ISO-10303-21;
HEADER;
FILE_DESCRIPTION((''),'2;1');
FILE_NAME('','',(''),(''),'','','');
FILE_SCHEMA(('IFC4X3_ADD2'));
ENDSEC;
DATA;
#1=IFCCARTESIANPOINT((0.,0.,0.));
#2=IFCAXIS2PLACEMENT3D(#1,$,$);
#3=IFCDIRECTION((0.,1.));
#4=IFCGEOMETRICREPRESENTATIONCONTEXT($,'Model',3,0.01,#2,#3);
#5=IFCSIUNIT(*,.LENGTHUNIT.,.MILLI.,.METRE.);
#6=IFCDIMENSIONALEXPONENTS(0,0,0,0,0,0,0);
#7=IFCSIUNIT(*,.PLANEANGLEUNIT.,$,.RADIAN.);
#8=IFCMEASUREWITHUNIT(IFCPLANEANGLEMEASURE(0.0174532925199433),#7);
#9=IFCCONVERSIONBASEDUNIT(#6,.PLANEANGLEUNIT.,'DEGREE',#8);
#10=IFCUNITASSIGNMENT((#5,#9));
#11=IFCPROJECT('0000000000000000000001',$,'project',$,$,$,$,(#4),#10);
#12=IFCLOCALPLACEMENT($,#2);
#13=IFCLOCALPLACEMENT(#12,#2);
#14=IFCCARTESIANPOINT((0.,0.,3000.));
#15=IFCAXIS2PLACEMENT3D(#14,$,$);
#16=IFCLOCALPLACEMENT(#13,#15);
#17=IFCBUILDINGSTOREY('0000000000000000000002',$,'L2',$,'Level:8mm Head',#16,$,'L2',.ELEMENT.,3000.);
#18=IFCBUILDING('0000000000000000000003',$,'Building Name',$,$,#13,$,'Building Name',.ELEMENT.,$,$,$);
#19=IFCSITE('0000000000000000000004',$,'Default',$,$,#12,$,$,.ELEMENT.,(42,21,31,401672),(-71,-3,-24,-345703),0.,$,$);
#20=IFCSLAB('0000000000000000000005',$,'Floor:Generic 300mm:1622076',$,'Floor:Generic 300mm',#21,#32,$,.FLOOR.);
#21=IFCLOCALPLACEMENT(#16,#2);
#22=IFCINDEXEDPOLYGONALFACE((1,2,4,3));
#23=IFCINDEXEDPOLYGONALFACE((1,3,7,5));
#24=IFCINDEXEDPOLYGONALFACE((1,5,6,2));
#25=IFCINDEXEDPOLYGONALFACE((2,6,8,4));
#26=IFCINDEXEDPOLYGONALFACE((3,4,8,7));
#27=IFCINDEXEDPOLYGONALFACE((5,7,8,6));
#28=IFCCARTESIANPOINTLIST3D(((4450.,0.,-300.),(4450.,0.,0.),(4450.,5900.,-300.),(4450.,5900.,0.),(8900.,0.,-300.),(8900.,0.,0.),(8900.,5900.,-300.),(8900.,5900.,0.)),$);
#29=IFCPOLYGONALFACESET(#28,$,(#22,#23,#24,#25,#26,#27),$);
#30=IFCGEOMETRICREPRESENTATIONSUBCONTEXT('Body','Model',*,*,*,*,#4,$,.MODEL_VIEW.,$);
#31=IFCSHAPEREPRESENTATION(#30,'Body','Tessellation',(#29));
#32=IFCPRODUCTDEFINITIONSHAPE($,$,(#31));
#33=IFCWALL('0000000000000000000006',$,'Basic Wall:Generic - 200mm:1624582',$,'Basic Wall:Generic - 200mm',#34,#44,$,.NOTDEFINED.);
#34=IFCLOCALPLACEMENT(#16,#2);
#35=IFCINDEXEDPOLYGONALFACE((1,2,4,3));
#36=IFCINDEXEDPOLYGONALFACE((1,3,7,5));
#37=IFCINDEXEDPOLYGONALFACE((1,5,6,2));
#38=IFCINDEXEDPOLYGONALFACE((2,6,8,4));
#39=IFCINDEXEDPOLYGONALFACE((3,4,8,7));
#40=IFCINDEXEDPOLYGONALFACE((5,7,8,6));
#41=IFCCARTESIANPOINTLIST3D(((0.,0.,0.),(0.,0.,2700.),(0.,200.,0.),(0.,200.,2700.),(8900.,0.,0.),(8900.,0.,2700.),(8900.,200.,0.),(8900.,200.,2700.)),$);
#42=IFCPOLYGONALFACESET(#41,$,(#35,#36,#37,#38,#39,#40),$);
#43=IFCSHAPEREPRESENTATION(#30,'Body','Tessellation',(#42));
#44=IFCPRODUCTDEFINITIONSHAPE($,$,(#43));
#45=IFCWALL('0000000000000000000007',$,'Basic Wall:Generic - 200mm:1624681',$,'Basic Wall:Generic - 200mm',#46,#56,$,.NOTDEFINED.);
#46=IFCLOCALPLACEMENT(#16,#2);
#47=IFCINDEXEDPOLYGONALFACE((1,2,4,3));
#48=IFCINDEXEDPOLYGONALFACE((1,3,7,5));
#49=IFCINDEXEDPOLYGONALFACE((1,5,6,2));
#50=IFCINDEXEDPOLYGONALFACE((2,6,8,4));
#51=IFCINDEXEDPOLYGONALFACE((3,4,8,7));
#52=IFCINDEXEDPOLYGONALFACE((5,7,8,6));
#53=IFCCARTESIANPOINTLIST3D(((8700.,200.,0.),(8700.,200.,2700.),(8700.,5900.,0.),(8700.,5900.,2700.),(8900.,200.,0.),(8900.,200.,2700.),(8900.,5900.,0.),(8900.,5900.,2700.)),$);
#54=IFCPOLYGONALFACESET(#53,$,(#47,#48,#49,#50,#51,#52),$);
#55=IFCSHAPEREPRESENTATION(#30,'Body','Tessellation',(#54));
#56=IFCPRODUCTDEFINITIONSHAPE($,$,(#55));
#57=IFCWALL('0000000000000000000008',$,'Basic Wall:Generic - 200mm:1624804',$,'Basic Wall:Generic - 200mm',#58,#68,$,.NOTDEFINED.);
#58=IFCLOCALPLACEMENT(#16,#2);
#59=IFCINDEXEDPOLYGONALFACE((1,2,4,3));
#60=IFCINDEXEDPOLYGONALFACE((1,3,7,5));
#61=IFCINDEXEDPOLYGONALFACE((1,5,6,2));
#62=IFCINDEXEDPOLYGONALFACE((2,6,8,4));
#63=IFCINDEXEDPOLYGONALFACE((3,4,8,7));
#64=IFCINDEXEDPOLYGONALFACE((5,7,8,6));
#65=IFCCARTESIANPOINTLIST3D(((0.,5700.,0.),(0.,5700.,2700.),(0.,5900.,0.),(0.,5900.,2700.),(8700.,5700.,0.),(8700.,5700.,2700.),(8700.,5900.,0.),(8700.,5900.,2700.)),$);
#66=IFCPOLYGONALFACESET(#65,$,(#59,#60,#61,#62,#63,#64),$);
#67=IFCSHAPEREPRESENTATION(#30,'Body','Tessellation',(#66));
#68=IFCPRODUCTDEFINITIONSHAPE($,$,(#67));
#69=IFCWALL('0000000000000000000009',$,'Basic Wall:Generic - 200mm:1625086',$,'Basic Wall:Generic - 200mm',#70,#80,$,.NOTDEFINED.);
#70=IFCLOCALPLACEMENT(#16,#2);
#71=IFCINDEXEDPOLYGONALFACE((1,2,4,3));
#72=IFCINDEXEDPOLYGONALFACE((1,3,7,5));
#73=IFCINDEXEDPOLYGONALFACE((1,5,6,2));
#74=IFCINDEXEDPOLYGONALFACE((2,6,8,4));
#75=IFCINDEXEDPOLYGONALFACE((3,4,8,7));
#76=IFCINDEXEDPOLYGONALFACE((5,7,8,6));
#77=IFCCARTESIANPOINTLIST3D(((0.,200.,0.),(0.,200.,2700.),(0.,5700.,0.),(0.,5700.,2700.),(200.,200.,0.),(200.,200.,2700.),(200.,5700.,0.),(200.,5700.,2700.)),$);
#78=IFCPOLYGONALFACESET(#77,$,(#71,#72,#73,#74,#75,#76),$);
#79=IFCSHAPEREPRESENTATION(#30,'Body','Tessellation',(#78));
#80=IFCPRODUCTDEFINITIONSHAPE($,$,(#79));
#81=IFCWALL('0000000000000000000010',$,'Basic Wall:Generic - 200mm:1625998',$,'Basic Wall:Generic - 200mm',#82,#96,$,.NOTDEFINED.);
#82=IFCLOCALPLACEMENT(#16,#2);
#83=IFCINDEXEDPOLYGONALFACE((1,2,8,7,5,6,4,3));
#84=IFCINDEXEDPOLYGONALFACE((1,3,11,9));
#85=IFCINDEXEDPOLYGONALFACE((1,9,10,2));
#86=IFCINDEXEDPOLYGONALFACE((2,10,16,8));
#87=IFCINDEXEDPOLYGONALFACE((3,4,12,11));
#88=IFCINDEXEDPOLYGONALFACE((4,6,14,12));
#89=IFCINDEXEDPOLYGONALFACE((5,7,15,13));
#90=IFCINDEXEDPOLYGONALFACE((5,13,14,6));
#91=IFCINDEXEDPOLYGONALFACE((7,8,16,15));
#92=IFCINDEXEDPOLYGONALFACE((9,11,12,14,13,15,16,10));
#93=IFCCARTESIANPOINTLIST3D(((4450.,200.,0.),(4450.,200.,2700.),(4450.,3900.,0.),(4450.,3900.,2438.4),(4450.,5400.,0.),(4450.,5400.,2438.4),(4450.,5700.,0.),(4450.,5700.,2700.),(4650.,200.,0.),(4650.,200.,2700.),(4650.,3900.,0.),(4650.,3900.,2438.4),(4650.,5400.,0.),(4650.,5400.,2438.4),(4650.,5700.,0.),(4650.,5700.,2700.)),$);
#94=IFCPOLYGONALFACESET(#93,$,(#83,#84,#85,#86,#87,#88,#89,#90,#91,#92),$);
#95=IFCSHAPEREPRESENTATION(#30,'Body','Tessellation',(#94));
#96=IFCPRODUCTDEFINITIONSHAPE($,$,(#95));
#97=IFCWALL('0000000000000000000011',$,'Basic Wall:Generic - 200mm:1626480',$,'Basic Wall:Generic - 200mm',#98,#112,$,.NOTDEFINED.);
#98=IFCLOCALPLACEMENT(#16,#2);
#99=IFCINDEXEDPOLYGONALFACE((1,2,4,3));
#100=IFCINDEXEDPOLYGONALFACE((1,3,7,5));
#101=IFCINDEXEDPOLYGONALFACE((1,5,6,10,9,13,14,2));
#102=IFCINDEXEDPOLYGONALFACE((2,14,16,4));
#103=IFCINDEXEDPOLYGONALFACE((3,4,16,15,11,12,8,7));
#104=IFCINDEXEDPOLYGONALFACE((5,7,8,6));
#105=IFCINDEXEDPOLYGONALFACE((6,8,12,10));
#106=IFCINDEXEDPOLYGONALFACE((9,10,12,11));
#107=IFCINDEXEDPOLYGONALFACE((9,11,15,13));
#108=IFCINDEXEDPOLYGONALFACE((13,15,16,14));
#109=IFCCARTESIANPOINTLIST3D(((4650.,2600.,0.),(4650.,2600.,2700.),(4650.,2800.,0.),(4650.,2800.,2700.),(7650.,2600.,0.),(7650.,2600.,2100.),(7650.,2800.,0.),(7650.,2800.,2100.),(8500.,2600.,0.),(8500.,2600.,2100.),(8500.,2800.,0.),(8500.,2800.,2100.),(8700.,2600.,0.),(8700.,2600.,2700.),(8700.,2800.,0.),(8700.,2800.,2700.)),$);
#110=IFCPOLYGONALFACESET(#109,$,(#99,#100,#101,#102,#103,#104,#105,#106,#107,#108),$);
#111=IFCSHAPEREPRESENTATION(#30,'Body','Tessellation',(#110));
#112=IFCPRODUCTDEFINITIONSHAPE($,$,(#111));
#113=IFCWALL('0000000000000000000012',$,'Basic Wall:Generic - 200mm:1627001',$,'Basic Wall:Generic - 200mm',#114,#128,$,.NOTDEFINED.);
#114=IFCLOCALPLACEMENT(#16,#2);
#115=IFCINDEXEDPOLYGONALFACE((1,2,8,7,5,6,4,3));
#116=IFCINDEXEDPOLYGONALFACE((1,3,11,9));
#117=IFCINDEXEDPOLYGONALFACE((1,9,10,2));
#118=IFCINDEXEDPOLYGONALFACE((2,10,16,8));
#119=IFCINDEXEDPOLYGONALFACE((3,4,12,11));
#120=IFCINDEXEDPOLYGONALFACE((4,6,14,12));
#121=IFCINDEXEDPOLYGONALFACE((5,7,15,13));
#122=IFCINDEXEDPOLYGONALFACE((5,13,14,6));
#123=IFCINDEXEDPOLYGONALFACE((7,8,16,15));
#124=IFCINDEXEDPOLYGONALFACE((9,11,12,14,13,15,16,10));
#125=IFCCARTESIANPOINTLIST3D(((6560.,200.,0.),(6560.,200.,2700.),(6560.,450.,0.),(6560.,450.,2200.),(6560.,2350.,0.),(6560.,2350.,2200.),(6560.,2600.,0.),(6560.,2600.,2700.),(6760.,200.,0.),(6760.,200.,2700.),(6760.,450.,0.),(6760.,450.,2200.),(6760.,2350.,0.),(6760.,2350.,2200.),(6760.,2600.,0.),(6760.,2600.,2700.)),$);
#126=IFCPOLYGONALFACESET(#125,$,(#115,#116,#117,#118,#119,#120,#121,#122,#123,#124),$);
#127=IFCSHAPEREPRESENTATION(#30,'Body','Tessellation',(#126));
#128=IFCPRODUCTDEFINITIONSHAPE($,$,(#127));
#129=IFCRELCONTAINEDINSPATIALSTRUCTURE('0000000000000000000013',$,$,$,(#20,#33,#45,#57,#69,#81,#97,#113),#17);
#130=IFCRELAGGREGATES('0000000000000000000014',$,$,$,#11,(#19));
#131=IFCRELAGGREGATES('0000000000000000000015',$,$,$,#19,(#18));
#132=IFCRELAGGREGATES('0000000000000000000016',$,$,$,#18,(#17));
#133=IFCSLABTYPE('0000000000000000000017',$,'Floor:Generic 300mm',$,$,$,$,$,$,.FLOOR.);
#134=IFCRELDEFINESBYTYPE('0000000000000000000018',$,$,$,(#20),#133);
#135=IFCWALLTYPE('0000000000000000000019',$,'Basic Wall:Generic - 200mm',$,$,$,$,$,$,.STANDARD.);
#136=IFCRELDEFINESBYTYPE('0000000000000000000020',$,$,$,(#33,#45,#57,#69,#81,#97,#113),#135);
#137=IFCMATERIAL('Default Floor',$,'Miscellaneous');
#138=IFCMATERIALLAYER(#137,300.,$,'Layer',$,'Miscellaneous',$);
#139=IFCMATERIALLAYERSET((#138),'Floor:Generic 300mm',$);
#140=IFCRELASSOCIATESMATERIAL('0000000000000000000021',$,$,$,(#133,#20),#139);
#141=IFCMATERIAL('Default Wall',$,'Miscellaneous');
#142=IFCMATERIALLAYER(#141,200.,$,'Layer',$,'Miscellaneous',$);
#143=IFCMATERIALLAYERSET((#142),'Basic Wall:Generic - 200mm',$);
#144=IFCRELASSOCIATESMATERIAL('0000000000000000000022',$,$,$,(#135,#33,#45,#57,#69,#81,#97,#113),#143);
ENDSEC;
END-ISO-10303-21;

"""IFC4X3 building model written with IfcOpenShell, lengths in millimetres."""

from ifc_helpers import new_model, entity, si_unit, converted_unit, direction, frame, frame_2d, origin, origin_2d_with_axis, place, context, subcontext, project, spatial, rectangle, extrude, material, layer, layer_set, layer_usage, type_object, element, save


model = new_model("IFC4X3")

# Units and contexts
model_context = context("Model", 3, precision=0.01, world=origin(), true_north=direction((0.0, 1.0)))
body_context = subcontext(model_context, "Body", "Model", "MODEL_VIEW")
ifc_project = project(units=[si_unit("LENGTHUNIT", "METRE", prefix="MILLI"), converted_unit("PLANEANGLEUNIT", "DEGREE", entity("IfcPlaneAngleMeasure", 0.0174532925199433), si_unit("PLANEANGLEUNIT", "RADIAN"), dimensions=[0, 0, 0, 0, 0, 0, 0])], contexts=[model_context])

# Site, building, storey
site_placement = place(None, origin())
site = spatial("IfcSite", under=ifc_project, at=site_placement, Name="Default", CompositionType="ELEMENT", RefLatitude=(42, 21, 31, 401672), RefLongitude=(-71, -3, -24, -345703), RefElevation=0.0)
building_placement = place(site_placement, origin())
building = spatial("IfcBuilding", under=site, at=building_placement, Name="Building Name", LongName="Building Name", CompositionType="ELEMENT")
storey_placement = place(building_placement, frame((0.0, 0.0, 3000.0)))
storey = spatial("IfcBuildingStorey", under=building, at=storey_placement, Name="L2", ObjectType="Level:8mm Head", LongName="L2", CompositionType="ELEMENT", Elevation=3000.0)

# Slab
ifc_material_1 = material(Name="Default Floor", Category="Miscellaneous")
ifc_layer_1 = layer(ifc_material_1, 300.0, Name="Layer", Category="Miscellaneous")
ifc_layer_set_1 = layer_set([ifc_layer_1], Name="Floor:Generic 300mm")
ifc_layer_usage = layer_usage(ifc_layer_set_1, "AXIS3", "POSITIVE", 0.0)
slab_type = type_object("IfcSlabType", Name="Floor:Generic 300mm", PredefinedType="FLOOR", material=ifc_layer_set_1)
slab_placement = place(storey_placement, origin())
element("IfcSlab", 1, at=slab_placement, inside=storey, type_object=slab_type, material=ifc_layer_usage, Name="Floor:Generic 300mm:1622076", ObjectType="Floor:Generic 300mm", PredefinedType="FLOOR", context=body_context, shape_type="SweptSolid", body=[
    extrude(rectangle(XDim=5900.0, YDim=4450.0, at=origin_2d_with_axis()), frame((6675.0, 2950.0, 0.0), z_axis=(0.0, 0.0, -1.0), x_axis=(0.0, 1.0, 0.0)), (0.0, 0.0, 1.0), 300.0),
])

# Walls
ifc_material_2 = material(Name="Default Wall", Category="Miscellaneous")
ifc_layer_2 = layer(ifc_material_2, 200.0, Name="Layer", Category="Miscellaneous")
ifc_layer_set_2 = layer_set([ifc_layer_2], Name="Basic Wall:Generic - 200mm")
wall_type = type_object("IfcWallType", Name="Basic Wall:Generic - 200mm", PredefinedType="STANDARD", material=ifc_layer_set_2)
wall_1_placement = place(storey_placement, frame((0.0, 100.0, 0.0)))
element("IfcWall", 2, at=wall_1_placement, inside=storey, type_object=wall_type, material=ifc_layer_set_2, Name="Basic Wall:Generic - 200mm:1624582", ObjectType="Basic Wall:Generic - 200mm", PredefinedType="NOTDEFINED", context=body_context, shape_type="SweptSolid", body=[
    extrude(rectangle(XDim=8900.0, YDim=200.0, at=frame_2d((4450.0, 0.0), x_axis=(-1.0, 0.0))), origin(), (0.0, 0.0, 1.0), 2700.0),
])
wall_2_placement = place(storey_placement, frame((8800.0, 200.0, 0.0), z_axis=(0.0, 0.0, 1.0), x_axis=(0.0, 1.0, 0.0)))
element("IfcWall", 3, at=wall_2_placement, inside=storey, type_object=wall_type, material=ifc_layer_set_2, Name="Basic Wall:Generic - 200mm:1624681", ObjectType="Basic Wall:Generic - 200mm", PredefinedType="NOTDEFINED", context=body_context, shape_type="SweptSolid", body=[
    extrude(rectangle(XDim=5700.0, YDim=200.0, at=frame_2d((2850.0, 0.0), x_axis=(-1.0, 0.0))), origin(), (0.0, 0.0, 1.0), 2700.0),
])
wall_3_placement = place(storey_placement, frame((8700.0, 5800.0, 0.0), z_axis=(0.0, 0.0, 1.0), x_axis=(-1.0, 0.0, 0.0)))
element("IfcWall", 4, at=wall_3_placement, inside=storey, type_object=wall_type, material=ifc_layer_set_2, Name="Basic Wall:Generic - 200mm:1624804", ObjectType="Basic Wall:Generic - 200mm", PredefinedType="NOTDEFINED", context=body_context, shape_type="SweptSolid", body=[
    extrude(rectangle(XDim=8700.0, YDim=200.0, at=frame_2d((4350.0, 0.0), x_axis=(-1.0, 0.0))), origin(), (0.0, 0.0, 1.0), 2700.0),
])
wall_4_placement = place(storey_placement, frame((100.0, 5700.0, 0.0), z_axis=(0.0, 0.0, 1.0), x_axis=(0.0, -1.0, 0.0)))
element("IfcWall", 5, at=wall_4_placement, inside=storey, type_object=wall_type, material=ifc_layer_set_2, Name="Basic Wall:Generic - 200mm:1625086", ObjectType="Basic Wall:Generic - 200mm", PredefinedType="NOTDEFINED", context=body_context, shape_type="SweptSolid", body=[
    extrude(rectangle(XDim=5500.0, YDim=200.0, at=frame_2d((2750.0, 0.0), x_axis=(-1.0, 0.0))), origin(), (0.0, 0.0, 1.0), 2700.0),
])

# Walls, openings
wall_5_placement = place(storey_placement, frame((4550.0, 200.0, 0.0), z_axis=(0.0, 0.0, 1.0), x_axis=(0.0, 1.0, 0.0)))
wall_5 = element("IfcWall", 6, at=wall_5_placement, inside=storey, type_object=wall_type, material=ifc_layer_set_2, Name="Basic Wall:Generic - 200mm:1625998", ObjectType="Basic Wall:Generic - 200mm", PredefinedType="NOTDEFINED", context=body_context, shape_type="SweptSolid", body=[
    extrude(rectangle(XDim=5500.0, YDim=200.0, at=frame_2d((2750.0, 0.0), x_axis=(1.0, 0.0))), origin(), (0.0, 0.0, 1.0), 2700.0),
])
opening_1_placement = place(wall_5_placement, frame((3700.0, 100.0, 0.0)))
element("IfcOpeningElement", 7, at=opening_1_placement, cuts=wall_5, PredefinedType="OPENING", context=body_context, shape_type="SweptSolid", body=[
    extrude(rectangle(XDim=2438.4, YDim=1500.0, at=frame_2d((0.0, 0.0), x_axis=(1.0, 0.0))), frame((750.0, -200.0, 1219.2), z_axis=(0.0, 1.0, 0.0), x_axis=(0.0, 0.0, -1.0)), (0.0, 0.0, 1.0), 200.0),
])
wall_6_placement = place(storey_placement, frame((8700.0, 2700.0, 0.0), z_axis=(0.0, 0.0, 1.0), x_axis=(-1.0, 0.0, 0.0)))
wall_6 = element("IfcWall", 8, at=wall_6_placement, inside=storey, type_object=wall_type, material=ifc_layer_set_2, Name="Basic Wall:Generic - 200mm:1626480", ObjectType="Basic Wall:Generic - 200mm", PredefinedType="NOTDEFINED", context=body_context, shape_type="SweptSolid", body=[
    extrude(rectangle(XDim=4050.0, YDim=200.0, at=frame_2d((2025.0, 0.0), x_axis=(1.0, 0.0))), origin(), (0.0, 0.0, 1.0), 2700.0),
])
opening_2_placement = place(wall_6_placement, frame((200.0, -100.0, 0.0)))
element("IfcOpeningElement", 9, at=opening_2_placement, cuts=wall_6, PredefinedType="OPENING", context=body_context, shape_type="SweptSolid", body=[
    extrude(rectangle(XDim=2100.0, YDim=850.0, at=frame_2d((1050.0, 425.0), x_axis=(1.0, 0.0))), frame((0.0, 0.0, 0.0), z_axis=(0.0, 1.0, 0.0), x_axis=(0.0, 0.0, 1.0)), (0.0, 0.0, 1.0), 200.0),
])
wall_7_placement = place(storey_placement, frame((6660.0, 2600.0, 0.0), z_axis=(0.0, 0.0, 1.0), x_axis=(0.0, -1.0, 0.0)))
wall_7 = element("IfcWall", 10, at=wall_7_placement, inside=storey, type_object=wall_type, material=ifc_layer_set_2, Name="Basic Wall:Generic - 200mm:1627001", ObjectType="Basic Wall:Generic - 200mm", PredefinedType="NOTDEFINED", context=body_context, shape_type="SweptSolid", body=[
    extrude(rectangle(XDim=2400.0, YDim=200.0, at=frame_2d((1200.0, 0.0), x_axis=(-1.0, 0.0))), origin(), (0.0, 0.0, 1.0), 2700.0),
])
opening_3_placement = place(wall_7_placement, frame((2150.0, -100.0, 0.0)))
element("IfcOpeningElement", 11, at=opening_3_placement, cuts=wall_7, PredefinedType="OPENING", context=body_context, shape_type="SweptSolid", body=[
    extrude(rectangle(XDim=2200.0, YDim=1900.0, at=frame_2d((0.0, 0.0), x_axis=(1.0, 0.0))), frame((-950.0, 0.0, 1100.0), z_axis=(0.0, 1.0, 0.0), x_axis=(0.0, 0.0, -1.0)), (0.0, 0.0, 1.0), 200.0),
])

save(model, "model.ifc")
